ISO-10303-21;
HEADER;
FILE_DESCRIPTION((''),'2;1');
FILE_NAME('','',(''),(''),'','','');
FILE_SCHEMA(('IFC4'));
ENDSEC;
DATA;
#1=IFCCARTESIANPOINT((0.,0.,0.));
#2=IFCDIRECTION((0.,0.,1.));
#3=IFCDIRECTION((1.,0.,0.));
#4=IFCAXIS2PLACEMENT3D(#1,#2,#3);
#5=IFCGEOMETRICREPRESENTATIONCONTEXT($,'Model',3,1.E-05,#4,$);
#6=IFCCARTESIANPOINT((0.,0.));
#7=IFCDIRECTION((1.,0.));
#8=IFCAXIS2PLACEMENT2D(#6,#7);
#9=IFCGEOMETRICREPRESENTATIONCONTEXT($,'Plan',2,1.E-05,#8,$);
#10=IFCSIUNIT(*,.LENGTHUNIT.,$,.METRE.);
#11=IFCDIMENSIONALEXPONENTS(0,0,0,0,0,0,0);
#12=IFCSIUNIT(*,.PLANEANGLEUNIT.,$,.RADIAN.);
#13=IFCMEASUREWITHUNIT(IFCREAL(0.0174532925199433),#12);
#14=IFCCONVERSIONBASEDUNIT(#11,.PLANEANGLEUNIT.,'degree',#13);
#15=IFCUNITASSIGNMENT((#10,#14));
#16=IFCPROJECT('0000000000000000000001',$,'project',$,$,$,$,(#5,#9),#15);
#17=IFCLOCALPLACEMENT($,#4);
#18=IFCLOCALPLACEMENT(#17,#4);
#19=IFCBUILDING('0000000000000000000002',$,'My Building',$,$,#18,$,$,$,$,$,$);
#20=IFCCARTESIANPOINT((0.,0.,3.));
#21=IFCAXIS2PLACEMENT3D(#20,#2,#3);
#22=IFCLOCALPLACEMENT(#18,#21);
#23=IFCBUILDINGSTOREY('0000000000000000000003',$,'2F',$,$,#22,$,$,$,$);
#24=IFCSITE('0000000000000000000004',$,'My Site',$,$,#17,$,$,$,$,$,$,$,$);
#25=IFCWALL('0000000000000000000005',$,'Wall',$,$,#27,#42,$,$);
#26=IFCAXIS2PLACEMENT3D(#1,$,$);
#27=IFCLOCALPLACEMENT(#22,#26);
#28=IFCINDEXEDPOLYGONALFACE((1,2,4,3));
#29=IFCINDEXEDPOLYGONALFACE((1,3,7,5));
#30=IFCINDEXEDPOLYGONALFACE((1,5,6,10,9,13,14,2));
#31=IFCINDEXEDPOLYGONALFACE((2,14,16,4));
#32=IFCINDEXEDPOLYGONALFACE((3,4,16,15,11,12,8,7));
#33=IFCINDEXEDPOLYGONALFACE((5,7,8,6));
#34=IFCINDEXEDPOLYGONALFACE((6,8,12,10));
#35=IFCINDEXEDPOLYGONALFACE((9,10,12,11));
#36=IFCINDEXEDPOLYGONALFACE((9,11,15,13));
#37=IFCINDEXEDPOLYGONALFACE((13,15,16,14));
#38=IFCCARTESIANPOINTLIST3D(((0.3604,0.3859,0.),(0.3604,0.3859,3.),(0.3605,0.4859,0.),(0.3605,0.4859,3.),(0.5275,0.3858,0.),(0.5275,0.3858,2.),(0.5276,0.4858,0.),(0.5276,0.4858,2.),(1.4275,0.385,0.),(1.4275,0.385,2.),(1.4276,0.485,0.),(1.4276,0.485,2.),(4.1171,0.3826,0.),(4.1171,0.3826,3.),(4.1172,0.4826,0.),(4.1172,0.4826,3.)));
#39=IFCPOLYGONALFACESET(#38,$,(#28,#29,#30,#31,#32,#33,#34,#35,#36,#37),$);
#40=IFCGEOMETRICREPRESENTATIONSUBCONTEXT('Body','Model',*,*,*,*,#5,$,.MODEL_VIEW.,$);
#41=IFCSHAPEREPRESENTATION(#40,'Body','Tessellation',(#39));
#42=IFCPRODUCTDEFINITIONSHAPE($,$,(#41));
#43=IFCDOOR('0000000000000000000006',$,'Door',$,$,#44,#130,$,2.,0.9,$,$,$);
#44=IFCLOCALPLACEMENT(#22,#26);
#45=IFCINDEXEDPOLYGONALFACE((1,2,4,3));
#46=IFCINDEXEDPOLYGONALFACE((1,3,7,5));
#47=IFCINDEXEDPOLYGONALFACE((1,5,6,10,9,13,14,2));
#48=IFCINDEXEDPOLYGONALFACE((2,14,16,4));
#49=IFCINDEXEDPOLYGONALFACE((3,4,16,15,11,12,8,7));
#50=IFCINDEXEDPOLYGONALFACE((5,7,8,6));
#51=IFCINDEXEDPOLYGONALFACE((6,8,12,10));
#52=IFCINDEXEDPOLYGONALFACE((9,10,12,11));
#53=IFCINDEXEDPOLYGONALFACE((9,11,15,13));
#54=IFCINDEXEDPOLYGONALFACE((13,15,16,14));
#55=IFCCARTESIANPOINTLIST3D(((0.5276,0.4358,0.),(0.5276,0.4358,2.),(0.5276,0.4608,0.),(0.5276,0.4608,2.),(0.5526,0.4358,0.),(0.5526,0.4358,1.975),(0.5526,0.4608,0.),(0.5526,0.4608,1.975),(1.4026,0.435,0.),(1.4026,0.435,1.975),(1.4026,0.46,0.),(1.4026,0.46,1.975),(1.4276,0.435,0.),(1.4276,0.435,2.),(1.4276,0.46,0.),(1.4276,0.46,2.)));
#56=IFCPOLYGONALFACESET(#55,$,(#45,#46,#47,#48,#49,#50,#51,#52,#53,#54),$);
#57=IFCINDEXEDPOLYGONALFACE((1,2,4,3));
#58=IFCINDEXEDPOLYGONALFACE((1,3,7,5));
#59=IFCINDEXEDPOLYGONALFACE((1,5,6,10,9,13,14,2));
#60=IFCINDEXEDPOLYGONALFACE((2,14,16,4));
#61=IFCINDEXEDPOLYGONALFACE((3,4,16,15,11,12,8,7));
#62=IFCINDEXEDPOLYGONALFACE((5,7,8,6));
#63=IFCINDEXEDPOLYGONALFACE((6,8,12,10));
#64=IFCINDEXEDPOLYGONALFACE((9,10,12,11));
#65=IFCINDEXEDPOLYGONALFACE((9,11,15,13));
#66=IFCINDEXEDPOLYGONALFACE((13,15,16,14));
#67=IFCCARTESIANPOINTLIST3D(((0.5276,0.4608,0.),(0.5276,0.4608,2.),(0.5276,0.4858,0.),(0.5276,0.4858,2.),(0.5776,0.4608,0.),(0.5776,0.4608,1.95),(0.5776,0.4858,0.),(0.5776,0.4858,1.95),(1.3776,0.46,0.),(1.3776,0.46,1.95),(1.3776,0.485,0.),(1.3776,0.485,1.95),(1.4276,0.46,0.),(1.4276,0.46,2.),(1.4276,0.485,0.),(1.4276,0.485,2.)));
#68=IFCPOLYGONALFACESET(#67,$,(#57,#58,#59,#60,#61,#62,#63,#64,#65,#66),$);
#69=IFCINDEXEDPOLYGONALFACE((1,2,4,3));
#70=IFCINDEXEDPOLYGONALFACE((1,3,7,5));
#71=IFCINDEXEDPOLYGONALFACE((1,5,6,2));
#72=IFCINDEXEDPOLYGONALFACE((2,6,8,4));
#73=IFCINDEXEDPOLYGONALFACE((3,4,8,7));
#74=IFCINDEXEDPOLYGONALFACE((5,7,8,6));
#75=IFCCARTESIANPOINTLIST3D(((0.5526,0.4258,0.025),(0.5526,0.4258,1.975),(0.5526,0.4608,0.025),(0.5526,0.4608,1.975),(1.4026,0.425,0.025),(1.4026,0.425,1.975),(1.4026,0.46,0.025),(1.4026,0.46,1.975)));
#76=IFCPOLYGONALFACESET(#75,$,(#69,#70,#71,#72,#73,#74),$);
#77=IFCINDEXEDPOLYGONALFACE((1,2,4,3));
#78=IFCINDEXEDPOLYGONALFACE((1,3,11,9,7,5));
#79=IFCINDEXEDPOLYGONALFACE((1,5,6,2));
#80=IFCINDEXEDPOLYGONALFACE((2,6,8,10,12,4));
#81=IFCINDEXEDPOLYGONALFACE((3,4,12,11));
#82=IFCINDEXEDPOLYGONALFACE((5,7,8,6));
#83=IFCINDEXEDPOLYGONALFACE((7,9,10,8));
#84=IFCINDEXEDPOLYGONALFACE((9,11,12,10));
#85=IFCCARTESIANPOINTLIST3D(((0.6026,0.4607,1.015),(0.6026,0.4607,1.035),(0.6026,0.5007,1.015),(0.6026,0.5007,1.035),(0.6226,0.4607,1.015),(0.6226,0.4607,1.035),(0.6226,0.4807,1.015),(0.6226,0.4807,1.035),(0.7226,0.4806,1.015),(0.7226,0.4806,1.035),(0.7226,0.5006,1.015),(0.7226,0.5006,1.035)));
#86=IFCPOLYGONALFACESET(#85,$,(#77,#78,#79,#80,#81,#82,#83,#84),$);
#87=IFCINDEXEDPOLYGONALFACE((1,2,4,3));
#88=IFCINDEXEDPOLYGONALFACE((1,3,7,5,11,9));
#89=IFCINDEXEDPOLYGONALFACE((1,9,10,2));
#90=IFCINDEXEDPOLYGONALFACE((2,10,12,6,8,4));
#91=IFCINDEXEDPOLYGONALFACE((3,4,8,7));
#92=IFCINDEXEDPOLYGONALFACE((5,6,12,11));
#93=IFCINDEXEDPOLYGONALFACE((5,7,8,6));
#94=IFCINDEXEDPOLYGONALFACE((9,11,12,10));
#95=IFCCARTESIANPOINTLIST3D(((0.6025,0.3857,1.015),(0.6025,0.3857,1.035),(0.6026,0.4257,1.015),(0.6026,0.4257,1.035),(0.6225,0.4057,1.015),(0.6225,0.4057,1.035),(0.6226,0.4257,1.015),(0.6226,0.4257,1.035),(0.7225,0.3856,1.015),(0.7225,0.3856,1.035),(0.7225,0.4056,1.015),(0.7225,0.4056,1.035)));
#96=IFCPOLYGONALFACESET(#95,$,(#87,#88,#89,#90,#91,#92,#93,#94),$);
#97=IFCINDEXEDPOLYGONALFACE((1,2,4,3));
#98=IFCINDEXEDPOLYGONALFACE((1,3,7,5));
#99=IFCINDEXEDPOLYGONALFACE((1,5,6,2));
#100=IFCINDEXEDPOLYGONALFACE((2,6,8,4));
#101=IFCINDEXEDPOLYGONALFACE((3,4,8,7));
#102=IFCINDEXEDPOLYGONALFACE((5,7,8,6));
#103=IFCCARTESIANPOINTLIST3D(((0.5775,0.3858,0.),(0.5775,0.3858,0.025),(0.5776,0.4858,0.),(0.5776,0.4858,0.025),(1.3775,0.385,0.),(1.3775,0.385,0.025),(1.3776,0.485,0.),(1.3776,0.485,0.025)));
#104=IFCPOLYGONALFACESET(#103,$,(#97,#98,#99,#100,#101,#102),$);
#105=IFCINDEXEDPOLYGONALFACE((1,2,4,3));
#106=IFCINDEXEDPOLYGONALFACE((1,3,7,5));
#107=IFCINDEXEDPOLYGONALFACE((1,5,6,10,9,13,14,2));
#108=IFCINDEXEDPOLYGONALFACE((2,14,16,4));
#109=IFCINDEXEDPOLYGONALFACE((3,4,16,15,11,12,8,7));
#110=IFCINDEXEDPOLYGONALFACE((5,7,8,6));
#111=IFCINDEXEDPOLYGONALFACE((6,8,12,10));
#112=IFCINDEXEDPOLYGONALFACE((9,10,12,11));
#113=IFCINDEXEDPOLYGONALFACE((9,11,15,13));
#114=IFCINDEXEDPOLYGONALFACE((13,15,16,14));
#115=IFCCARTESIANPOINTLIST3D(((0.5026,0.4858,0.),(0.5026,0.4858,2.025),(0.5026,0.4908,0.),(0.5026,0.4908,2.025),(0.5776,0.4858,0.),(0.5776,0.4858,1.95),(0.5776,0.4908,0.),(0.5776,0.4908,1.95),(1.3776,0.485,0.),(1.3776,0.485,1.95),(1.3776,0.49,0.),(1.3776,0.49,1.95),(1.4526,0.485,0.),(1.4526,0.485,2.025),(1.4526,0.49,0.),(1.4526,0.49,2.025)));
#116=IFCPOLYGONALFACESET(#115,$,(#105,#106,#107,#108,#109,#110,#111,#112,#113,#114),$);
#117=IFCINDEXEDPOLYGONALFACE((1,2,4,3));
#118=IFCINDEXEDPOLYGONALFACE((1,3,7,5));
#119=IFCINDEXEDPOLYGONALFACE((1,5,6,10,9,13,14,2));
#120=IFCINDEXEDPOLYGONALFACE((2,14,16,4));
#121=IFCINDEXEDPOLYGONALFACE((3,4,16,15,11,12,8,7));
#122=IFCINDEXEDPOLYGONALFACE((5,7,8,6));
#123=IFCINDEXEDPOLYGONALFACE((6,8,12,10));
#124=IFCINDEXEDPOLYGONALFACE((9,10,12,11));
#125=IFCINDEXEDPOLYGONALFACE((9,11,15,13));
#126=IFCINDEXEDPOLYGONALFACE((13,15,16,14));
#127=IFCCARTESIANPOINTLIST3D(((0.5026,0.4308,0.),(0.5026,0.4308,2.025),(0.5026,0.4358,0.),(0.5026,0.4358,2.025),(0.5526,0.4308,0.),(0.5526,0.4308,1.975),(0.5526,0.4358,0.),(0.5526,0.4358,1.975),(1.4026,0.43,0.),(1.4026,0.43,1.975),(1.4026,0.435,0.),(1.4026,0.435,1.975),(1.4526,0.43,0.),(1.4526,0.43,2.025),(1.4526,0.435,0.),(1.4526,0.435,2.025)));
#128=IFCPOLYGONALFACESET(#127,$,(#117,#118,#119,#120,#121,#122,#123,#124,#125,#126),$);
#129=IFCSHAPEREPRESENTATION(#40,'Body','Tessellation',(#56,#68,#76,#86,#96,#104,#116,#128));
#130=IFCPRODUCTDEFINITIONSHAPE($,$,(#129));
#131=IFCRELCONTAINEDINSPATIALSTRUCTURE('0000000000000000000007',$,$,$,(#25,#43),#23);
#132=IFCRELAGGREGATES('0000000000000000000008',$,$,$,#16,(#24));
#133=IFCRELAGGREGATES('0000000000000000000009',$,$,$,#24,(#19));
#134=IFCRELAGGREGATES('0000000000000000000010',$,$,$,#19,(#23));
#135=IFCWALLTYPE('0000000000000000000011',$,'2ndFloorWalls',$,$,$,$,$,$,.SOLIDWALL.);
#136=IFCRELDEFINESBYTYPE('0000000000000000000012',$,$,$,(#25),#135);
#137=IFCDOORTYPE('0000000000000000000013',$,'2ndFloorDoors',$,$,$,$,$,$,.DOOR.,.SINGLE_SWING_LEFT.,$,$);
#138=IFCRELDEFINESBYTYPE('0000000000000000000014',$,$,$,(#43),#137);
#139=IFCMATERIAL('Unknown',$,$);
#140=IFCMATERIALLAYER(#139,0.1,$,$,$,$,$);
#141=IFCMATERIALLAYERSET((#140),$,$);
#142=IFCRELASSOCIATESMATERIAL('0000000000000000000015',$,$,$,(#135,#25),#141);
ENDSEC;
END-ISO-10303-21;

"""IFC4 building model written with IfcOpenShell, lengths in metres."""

from ifc_helpers import new_model, entity, si_unit, converted_unit, frame, origin_with_axes, origin_2d_with_axis, place, context, subcontext, project, spatial, line, indexed_curve, outline, extrude, shape, source, transform, mapped, material, layer, layer_set, layer_usage, type_object, type_shapes, element, fill, save


model = new_model("IFC4")

# Units and contexts
model_context = context("Model", 3, precision=1e-05, world=origin_with_axes())
plan_context = context("Plan", 2, precision=1e-05, world=origin_2d_with_axis())
body_context_1 = subcontext(model_context, "Body", "Model", "MODEL_VIEW")
body_context_2 = subcontext(plan_context, "Body", "Plan", "PLAN_VIEW")
ifc_project = project(units=[si_unit("LENGTHUNIT", "METRE"), converted_unit("PLANEANGLEUNIT", "degree", entity("IfcReal", 0.0174532925199433), si_unit("PLANEANGLEUNIT", "RADIAN"), dimensions=[0, 0, 0, 0, 0, 0, 0])], contexts=[model_context, plan_context])

# Site, building, storey
site_placement = place(None, origin_with_axes())
site = spatial("IfcSite", under=ifc_project, at=site_placement, Name="My Site")
building_placement = place(site_placement, origin_with_axes())
building = spatial("IfcBuilding", under=site, at=building_placement, Name="My Building")
storey_placement = place(building_placement, frame((0.0, 0.0, 3.0), z_axis=(0.0, 0.0, 1.0), x_axis=(1.0, 0.0, 0.0)))
storey = spatial("IfcBuildingStorey", under=building, at=storey_placement, Name="2F")

# Shared definitions
ifc_material = material(Name="Unknown")

# Shared definitions
ifc_layer_1 = layer(ifc_material, 0.1)
ifc_layer_set_1 = layer_set([ifc_layer_1])
wall_type = type_object("IfcWallType", Name="2ndFloorWalls", PredefinedType="SOLIDWALL", material=ifc_layer_set_1)

# Shared definitions
shared_shape_1 = source(origin_with_axes(), body_context_1, "Body", "SweptSolid", [
    extrude(outline(indexed_curve([(0.0, 0.0), (0.9, 0.0), (0.9, 2.0), (0.0, 2.0)], segments=[line(1, 2, 3, 4, 1)])), frame((0.0, -0.6, 0.0), z_axis=(0.0, -1.0, 0.0), x_axis=(1.0, 0.0, 0.0)), (0.0, 0.0, -1.0), 1.2),
])
door_type = type_object("IfcDoorType", Name="2ndFloorDoors", OperationType="SINGLE_SWING_LEFT", PredefinedType="DOOR")
shared_shape_2 = source(origin_with_axes(), body_context_1, "Body", "SweptSolid", [
    extrude(outline(indexed_curve([(0.0, 0.0), (0.0, 2.0), (0.9, 2.0), (0.9, 0.0), (0.875, 0.0), (0.875, 1.975), (0.025, 1.975), (0.025, 0.0)], segments=[line(1, 2, 3, 4, 5, 6, 7, 8, 1)])), frame((0.0, 0.025, 0.0), z_axis=(0.0, -1.0, 0.0), x_axis=(1.0, 0.0, 0.0)), (0.0, 0.0, -1.0), 0.025),
    extrude(outline(indexed_curve([(0.0, 0.0), (0.0, 2.0), (0.9, 2.0), (0.9, 0.0), (0.85, 0.0), (0.85, 1.95), (0.05, 1.95), (0.05, 0.0)], segments=[line(1, 2, 3, 4, 5, 6, 7, 8, 1)])), frame((0.0, 0.0, 0.0), z_axis=(0.0, -1.0, 0.0), x_axis=(1.0, 0.0, 0.0)), (0.0, 0.0, -1.0), 0.025),
    extrude(outline(indexed_curve([(0.0, 0.0), (0.85, 0.0), (0.85, 0.035), (0.0, 0.035)], segments=[line(1, 2, 3, 4, 1)])), frame((0.025, 0.025, 0.025), z_axis=(0.0, 0.0, 1.0), x_axis=(1.0, 0.0, 0.0)), (0.0, 0.0, 1.0), 1.95),
    extrude(outline(indexed_curve([(0.0, 0.0), (0.0, -0.04), (-0.12, -0.04), (-0.12, -0.02), (-0.02, -0.02), (-0.02, 0.0)], segments=[line(1, 2, 3, 4, 5, 6, 1)])), frame((0.825, 0.025, 1.015), z_axis=(0.0, 0.0, 1.0), x_axis=(1.0, 0.0, 0.0)), (0.0, 0.0, 1.0), 0.02),
    extrude(outline(indexed_curve([(0.0, 0.0), (0.0, 0.04), (-0.12, 0.04), (-0.12, 0.02), (-0.02, 0.02), (-0.02, 0.0)], segments=[line(1, 2, 3, 4, 5, 6, 1)])), frame((0.825, 0.06, 1.015), z_axis=(0.0, 0.0, 1.0), x_axis=(1.0, 0.0, 0.0)), (0.0, 0.0, 1.0), 0.02),
    extrude(outline(indexed_curve([(0.0, 0.0), (0.8, 0.0), (0.8, 0.1), (0.0, 0.1)], segments=[line(1, 2, 3, 4, 1)])), frame((0.05, 0.0, 0.0), z_axis=(0.0, 0.0, 1.0), x_axis=(1.0, 0.0, 0.0)), (0.0, 0.0, 1.0), 0.025),
    extrude(outline(indexed_curve([(0.0, 0.0), (0.0, 2.025), (0.95, 2.025), (0.95, 0.0), (0.875, 0.0), (0.875, 1.95), (0.075, 1.95), (0.075, 0.0)], segments=[line(1, 2, 3, 4, 5, 6, 7, 8, 1)])), frame((-0.025, -0.005, 0.0), z_axis=(0.0, -1.0, 0.0), x_axis=(1.0, 0.0, 0.0)), (0.0, 0.0, -1.0), 0.005),
    extrude(outline(indexed_curve([(0.0, 0.0), (0.0, 2.025), (0.95, 2.025), (0.95, 0.0), (0.9, 0.0), (0.9, 1.975), (0.05, 1.975), (0.05, 0.0)], segments=[line(1, 2, 3, 4, 5, 6, 7, 8, 1)])), frame((-0.025, 0.05, 0.0), z_axis=(0.0, -1.0, 0.0), x_axis=(1.0, 0.0, 0.0)), (0.0, 0.0, -1.0), 0.005),
])
shared_shape_3 = source(origin_with_axes(), body_context_2, "Body", "Curve2D", [
    entity("IfcIndexedPolyCurve", entity("IfcCartesianPointList2D", [[0.0, 0.0], [0.0, 0.05], [0.025, 0.05], [0.025, 0.025], [0.05, 0.025], [0.05, 0.0]]), [entity("IfcLineIndex", [1, 2, 3, 4, 5, 6, 1])]),
    entity("IfcIndexedPolyCurve", entity("IfcCartesianPointList2D", [[0.9, 0.0], [0.9, 0.05], [0.875, 0.05], [0.875, 0.025], [0.85, 0.025], [0.85, 0.0]]), [entity("IfcLineIndex", [1, 2, 3, 4, 5, 6, 1])]),
    entity("IfcTrimmedCurve", entity("IfcEllipse", entity("IfcAxis2Placement2D", entity("IfcCartesianPoint", [0.06, 0.05]), entity("IfcDirection", [1.0, 0.0])), 0.815, 0.85), [entity("IfcCartesianPoint", [0.875, 0.05])], [entity("IfcCartesianPoint", [0.06, 0.9])], True, "CARTESIAN"),
    entity("IfcIndexedPolyCurve", entity("IfcCartesianPointList2D", [[0.025, 0.05], [0.06, 0.05], [0.06, 0.9], [0.025, 0.9]]), [entity("IfcLineIndex", [1, 2, 3, 4, 1])]),
])
type_shapes(door_type, [shared_shape_2, shared_shape_3])

# Wall, opening, door
ifc_layer_usage_1 = layer_usage(ifc_layer_set_1, "AXIS2", "POSITIVE", 0.0)
wall_1_placement = place(storey_placement, frame((4.1172, 0.4826, 0.0), z_axis=(0.0, 0.0, 1.0), x_axis=(-1.0, 0.00089, 0.0)))
wall_1 = element("IfcWall", 1, at=wall_1_placement, inside=storey, type_object=wall_type, material=ifc_layer_usage_1, Name="Wall", context=body_context_1, shape_type="SweptSolid", body=[
    extrude(outline(indexed_curve([(0.0, 0.0), (0.0, 0.1), (3.7566, 0.1), (3.7566, 0.0)], segments=[line(1, 2, 3, 4, 1)])), origin_with_axes(), (0.0, 0.0, 1.0), 3.0),
])
opening_1_placement = place(wall_1_placement, frame((2.6896, 0.0, 0.0), z_axis=(0.0, 0.0, 1.0), x_axis=(1.0, 0.0, 0.0)))
opening_1 = element("IfcOpeningElement", 2, at=opening_1_placement, cuts=wall_1, PredefinedType="OPENING", context=body_context_1, shape_type="MappedRepresentation", body=[
    mapped(shared_shape_1, transform((0.0, 0.0, 0.0), x_axis=(1.0, 0.0, 0.0), y_axis=(0.0, 1.0, 0.0), z_axis=(0.0, 0.0, 1.0), scale=1.0)),
])
door_1_placement = place(opening_1_placement, frame((0.0, 0.0, 0.0), z_axis=(0.0, 0.0, 1.0), x_axis=(1.0, 0.0, 0.0)))
door_1 = element("IfcDoor", 3, at=door_1_placement, inside=storey, type_object=door_type, Name="Door", OverallHeight=2.0, OverallWidth=0.9, shapes=[
    shape(body_context_1, "Body", "MappedRepresentation", [mapped(shared_shape_2, transform((0.0, 0.0, 0.0), x_axis=(1.0, 0.0, 0.0), y_axis=(0.0, 1.0, 0.0), z_axis=(0.0, 0.0, 1.0), scale=1.0))]),
    shape(body_context_2, "Body", "MappedRepresentation", [mapped(shared_shape_3, transform((0.0, 0.0, 0.0), x_axis=(1.0, 0.0, 0.0), y_axis=(0.0, 1.0, 0.0), z_axis=(0.0, 0.0, 1.0), scale=1.0))]),
])
fill(opening_1, door_1)

save(model, "model.ifc")
